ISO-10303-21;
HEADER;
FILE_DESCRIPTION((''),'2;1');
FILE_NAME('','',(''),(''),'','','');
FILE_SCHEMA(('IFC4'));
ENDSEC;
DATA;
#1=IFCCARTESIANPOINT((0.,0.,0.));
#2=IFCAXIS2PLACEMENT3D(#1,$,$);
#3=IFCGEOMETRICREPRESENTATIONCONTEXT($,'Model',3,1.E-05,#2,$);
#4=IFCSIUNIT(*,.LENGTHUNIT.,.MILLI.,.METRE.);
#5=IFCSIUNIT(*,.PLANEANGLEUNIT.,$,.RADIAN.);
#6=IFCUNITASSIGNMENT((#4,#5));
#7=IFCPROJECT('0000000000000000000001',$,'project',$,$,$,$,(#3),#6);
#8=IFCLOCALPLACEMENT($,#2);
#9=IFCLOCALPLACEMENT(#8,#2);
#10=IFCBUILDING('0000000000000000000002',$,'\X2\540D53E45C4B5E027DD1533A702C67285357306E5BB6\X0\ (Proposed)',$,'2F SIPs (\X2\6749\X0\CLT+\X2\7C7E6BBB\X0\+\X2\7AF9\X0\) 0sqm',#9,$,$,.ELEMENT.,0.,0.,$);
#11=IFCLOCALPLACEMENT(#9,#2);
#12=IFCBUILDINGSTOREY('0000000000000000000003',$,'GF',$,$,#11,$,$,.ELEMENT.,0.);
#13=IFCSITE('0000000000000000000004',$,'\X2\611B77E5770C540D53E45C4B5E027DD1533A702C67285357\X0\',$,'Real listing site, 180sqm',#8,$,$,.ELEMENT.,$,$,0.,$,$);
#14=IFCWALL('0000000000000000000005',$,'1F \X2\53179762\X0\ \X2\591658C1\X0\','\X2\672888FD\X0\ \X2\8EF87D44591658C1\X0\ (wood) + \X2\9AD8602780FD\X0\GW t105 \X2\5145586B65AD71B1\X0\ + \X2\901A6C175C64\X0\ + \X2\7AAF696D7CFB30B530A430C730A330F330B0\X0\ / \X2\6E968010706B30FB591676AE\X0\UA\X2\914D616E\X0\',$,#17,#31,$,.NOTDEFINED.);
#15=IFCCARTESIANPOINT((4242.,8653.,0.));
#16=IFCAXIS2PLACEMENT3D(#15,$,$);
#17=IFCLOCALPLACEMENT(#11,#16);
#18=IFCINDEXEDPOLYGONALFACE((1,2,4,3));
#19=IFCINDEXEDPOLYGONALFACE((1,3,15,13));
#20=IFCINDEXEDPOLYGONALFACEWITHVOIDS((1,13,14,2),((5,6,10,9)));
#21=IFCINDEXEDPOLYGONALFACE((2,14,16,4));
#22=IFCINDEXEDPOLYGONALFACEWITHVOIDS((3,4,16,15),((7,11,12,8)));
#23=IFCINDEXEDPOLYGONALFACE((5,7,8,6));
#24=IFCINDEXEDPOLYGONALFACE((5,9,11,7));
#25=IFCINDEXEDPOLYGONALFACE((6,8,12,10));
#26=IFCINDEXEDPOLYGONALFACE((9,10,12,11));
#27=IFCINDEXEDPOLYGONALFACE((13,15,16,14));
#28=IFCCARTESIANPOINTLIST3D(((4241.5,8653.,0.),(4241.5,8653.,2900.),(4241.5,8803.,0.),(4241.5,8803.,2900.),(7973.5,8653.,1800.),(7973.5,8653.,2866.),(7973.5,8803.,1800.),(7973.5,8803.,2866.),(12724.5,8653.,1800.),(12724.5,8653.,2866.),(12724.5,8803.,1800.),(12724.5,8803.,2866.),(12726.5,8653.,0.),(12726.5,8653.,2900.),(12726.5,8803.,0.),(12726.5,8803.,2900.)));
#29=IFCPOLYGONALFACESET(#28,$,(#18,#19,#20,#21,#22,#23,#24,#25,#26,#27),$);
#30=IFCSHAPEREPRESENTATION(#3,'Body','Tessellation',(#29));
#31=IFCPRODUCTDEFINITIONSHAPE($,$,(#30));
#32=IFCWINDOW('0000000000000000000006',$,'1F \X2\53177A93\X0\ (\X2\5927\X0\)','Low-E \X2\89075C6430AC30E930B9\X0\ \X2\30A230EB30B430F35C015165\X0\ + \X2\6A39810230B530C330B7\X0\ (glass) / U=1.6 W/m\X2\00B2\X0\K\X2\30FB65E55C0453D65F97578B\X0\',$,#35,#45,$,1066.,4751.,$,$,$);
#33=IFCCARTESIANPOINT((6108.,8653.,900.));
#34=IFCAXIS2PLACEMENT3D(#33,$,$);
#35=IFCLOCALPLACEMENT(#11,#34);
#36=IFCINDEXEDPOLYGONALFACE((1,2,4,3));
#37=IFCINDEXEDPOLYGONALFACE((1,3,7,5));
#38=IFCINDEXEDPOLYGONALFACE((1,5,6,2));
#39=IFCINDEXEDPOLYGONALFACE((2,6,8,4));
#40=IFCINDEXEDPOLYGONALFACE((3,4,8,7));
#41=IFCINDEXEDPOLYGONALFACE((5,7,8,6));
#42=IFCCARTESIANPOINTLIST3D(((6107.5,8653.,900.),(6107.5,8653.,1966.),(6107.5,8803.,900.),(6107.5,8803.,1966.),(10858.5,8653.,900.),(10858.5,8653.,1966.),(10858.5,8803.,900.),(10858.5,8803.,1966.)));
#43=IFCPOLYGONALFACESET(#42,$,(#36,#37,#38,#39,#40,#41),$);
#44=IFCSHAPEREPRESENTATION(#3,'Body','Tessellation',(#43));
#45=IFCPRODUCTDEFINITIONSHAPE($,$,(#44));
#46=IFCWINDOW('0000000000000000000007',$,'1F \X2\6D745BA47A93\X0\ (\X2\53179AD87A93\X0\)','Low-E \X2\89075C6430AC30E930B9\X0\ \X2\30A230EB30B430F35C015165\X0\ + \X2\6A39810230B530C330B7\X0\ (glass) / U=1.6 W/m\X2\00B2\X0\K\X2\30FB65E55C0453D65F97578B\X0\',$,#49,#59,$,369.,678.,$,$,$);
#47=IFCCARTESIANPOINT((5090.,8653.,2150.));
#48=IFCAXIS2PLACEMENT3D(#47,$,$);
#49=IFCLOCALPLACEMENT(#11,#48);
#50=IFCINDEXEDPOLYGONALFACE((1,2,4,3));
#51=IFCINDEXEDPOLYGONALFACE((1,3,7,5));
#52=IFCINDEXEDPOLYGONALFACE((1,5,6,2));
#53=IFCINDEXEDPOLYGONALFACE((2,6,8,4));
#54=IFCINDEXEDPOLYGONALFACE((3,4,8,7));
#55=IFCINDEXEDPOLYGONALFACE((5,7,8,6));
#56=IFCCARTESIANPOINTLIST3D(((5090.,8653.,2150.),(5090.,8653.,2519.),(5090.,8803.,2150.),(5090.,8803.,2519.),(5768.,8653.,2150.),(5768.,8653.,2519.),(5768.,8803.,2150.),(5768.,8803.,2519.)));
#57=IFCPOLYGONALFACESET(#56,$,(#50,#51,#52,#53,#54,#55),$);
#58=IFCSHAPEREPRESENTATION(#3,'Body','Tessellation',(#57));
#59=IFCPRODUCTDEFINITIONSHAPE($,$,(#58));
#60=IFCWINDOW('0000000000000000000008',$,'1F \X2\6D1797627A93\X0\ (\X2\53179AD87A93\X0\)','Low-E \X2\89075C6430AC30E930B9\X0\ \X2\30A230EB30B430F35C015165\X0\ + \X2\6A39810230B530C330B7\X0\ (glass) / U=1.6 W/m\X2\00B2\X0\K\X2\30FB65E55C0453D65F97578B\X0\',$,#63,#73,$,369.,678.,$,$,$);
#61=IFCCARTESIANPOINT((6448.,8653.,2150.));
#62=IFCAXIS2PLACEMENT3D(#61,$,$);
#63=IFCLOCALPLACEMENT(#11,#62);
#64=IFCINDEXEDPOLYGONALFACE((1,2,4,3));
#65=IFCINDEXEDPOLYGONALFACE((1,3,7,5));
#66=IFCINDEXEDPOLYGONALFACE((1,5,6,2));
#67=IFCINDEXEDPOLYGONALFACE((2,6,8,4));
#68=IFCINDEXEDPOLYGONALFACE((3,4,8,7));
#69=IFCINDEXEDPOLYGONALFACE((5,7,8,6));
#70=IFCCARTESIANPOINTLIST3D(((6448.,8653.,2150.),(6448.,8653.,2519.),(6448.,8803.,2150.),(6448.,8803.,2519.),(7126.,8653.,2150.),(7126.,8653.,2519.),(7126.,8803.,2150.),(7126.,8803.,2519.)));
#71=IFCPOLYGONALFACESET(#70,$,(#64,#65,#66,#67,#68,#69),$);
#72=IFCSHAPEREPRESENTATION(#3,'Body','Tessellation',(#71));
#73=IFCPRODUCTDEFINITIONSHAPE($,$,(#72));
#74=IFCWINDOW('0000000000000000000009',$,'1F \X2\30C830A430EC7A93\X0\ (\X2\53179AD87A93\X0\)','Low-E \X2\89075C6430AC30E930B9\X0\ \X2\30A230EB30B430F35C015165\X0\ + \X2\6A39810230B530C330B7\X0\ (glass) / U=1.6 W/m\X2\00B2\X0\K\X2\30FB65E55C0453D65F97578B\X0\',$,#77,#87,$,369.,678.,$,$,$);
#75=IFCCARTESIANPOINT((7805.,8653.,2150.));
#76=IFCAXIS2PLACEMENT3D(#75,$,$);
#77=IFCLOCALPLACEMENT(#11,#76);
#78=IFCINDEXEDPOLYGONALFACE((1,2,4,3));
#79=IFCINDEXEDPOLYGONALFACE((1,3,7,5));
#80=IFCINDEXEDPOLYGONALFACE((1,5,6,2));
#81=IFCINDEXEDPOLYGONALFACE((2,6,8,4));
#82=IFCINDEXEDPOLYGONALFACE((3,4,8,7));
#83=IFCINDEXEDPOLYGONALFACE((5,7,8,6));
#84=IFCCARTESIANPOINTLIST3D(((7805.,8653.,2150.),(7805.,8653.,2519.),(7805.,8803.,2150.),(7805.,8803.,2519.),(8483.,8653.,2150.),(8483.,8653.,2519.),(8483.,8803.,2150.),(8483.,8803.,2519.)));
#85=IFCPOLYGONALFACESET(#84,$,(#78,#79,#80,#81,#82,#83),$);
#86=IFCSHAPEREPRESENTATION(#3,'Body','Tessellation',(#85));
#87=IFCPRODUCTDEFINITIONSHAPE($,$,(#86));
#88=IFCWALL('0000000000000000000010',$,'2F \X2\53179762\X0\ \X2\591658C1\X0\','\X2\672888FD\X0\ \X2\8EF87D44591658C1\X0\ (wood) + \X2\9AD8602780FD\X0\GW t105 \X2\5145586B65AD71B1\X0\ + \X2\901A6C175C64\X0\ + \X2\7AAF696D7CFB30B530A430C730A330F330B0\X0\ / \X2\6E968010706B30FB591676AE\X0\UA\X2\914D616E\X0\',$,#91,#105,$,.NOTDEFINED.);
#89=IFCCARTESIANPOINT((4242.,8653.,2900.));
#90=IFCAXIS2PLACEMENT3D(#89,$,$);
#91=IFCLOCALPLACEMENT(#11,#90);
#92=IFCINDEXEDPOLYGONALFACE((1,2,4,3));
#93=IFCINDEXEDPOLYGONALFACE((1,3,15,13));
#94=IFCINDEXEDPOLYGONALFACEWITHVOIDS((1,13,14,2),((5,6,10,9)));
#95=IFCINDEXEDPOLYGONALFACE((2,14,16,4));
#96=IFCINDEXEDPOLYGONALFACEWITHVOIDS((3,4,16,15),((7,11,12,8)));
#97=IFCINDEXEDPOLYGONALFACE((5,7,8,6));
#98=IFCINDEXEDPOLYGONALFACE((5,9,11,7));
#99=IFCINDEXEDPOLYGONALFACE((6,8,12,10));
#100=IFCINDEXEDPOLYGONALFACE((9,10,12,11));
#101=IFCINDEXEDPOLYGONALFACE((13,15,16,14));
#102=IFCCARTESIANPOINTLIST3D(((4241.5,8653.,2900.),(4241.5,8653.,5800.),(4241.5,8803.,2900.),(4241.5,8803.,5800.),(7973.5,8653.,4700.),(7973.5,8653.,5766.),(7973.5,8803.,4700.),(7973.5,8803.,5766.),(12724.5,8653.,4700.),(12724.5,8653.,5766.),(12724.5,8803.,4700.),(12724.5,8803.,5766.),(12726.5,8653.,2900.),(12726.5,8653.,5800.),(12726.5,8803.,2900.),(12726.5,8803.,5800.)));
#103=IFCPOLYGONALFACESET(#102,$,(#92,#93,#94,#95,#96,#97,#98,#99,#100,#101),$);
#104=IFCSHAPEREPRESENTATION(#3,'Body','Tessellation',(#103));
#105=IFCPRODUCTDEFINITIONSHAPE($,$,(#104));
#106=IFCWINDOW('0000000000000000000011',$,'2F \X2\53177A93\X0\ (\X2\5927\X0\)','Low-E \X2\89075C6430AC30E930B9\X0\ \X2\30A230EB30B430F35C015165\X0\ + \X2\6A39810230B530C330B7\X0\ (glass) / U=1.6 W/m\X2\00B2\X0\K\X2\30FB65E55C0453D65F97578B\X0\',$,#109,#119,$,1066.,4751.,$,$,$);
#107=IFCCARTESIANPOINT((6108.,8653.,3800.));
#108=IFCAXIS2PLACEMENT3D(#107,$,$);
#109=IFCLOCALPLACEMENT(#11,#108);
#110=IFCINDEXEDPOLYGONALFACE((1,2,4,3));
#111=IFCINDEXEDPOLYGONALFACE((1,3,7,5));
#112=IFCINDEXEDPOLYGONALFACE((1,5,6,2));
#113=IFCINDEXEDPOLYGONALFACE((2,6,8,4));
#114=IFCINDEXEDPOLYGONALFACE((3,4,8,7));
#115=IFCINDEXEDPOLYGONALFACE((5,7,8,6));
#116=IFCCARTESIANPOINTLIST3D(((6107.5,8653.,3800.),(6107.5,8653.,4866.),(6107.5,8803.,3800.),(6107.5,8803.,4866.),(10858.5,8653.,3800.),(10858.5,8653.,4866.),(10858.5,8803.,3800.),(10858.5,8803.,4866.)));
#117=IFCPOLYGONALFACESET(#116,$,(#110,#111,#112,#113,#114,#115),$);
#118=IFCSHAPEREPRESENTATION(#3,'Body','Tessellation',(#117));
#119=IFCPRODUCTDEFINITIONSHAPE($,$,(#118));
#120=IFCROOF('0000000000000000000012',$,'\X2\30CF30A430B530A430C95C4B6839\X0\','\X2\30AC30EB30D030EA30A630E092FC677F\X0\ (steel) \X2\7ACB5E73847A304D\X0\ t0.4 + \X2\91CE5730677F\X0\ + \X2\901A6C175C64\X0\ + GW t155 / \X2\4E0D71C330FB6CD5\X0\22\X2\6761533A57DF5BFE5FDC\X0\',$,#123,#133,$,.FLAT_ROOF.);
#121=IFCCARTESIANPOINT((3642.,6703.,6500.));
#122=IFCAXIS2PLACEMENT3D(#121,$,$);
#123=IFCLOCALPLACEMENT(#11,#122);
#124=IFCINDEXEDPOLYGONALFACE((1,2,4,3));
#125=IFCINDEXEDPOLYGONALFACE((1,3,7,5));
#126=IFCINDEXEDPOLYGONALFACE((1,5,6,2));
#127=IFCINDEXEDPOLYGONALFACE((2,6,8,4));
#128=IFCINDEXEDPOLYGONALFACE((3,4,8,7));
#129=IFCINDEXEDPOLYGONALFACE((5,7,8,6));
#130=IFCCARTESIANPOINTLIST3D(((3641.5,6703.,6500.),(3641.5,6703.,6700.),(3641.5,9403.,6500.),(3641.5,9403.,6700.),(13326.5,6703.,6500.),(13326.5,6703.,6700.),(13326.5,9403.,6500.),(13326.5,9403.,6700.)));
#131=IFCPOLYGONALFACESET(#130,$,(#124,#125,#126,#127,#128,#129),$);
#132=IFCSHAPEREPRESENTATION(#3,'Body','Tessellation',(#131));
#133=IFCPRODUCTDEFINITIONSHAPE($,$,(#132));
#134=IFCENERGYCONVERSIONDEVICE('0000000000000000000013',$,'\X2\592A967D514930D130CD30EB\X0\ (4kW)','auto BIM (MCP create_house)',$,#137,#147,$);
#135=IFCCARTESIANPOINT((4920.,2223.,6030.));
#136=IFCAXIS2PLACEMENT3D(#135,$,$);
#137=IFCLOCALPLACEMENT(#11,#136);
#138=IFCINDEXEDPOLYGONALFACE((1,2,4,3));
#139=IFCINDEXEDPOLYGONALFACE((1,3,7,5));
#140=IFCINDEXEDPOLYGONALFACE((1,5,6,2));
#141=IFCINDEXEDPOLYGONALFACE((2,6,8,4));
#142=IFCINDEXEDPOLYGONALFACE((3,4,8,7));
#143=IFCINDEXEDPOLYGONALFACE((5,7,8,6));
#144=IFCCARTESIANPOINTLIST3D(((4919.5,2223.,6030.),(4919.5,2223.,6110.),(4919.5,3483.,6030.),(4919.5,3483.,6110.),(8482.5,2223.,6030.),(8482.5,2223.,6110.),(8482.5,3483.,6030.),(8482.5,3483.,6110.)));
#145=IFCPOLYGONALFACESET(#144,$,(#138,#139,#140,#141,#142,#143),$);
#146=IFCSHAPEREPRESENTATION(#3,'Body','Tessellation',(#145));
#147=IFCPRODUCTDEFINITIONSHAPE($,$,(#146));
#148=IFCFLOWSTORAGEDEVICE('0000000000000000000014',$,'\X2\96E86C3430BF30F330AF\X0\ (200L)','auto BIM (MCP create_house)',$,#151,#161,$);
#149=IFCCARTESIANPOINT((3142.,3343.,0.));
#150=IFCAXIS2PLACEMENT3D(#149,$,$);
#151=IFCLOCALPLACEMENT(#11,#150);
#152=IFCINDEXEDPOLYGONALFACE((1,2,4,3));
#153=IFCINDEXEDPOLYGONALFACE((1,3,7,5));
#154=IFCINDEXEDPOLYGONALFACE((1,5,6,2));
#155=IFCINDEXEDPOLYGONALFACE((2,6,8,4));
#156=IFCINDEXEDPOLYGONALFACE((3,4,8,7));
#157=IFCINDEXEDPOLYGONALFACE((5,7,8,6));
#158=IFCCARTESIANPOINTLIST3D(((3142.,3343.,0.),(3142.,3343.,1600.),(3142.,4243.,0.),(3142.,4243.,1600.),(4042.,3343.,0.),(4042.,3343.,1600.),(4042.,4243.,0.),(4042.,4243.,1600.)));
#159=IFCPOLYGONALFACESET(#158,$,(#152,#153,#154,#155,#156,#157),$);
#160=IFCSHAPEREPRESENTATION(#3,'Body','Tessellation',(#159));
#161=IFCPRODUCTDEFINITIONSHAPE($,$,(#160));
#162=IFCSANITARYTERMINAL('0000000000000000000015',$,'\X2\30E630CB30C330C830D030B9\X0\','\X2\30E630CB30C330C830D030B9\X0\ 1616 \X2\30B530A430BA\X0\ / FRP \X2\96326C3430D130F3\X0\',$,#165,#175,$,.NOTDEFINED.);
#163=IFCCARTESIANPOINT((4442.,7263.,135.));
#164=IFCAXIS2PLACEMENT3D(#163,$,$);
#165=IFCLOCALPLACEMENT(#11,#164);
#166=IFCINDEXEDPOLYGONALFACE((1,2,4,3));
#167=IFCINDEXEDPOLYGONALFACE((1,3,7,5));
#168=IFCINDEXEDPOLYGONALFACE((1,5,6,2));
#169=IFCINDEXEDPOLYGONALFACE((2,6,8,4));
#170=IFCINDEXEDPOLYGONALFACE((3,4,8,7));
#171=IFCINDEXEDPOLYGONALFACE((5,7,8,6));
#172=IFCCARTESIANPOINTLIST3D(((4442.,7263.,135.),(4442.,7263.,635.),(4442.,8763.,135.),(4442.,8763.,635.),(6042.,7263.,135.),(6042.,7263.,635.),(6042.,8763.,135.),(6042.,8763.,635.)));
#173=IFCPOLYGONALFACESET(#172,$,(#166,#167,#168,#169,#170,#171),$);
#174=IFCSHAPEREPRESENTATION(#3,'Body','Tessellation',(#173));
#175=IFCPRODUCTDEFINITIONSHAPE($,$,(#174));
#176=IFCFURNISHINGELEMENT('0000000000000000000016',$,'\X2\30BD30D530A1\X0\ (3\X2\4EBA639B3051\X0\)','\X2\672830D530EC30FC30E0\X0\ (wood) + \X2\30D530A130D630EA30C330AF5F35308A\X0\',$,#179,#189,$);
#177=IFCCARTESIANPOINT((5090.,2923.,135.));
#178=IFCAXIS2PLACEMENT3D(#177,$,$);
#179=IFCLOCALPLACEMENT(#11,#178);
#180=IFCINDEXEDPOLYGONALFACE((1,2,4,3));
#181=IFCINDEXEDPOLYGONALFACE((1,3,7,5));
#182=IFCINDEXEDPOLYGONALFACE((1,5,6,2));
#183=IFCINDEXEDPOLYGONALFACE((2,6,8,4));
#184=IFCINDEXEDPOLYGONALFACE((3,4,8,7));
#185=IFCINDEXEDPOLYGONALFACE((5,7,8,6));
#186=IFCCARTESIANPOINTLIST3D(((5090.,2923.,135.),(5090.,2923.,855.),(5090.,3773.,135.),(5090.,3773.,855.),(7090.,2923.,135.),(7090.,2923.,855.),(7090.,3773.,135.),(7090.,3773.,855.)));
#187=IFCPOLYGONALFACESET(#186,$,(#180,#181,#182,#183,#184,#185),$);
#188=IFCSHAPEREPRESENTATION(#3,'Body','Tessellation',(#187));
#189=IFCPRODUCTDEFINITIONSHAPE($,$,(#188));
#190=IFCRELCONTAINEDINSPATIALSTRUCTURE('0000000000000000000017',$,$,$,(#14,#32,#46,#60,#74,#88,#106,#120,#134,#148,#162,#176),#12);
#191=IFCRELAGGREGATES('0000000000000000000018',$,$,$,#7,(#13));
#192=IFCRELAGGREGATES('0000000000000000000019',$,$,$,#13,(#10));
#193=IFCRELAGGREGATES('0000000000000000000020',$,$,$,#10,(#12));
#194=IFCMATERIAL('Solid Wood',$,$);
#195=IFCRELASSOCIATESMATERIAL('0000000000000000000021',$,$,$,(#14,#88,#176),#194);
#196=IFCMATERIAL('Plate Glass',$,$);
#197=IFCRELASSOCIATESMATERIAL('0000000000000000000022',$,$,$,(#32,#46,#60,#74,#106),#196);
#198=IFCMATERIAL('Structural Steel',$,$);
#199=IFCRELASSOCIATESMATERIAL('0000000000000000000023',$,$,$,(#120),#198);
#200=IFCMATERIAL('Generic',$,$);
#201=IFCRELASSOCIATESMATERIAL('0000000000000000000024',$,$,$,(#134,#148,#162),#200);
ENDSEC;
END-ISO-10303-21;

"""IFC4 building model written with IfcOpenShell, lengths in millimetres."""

from ifc_helpers import new_model, si_unit, frame, frame_2d, origin, place, context, project, spatial, rectangle, extrude, material, element, fill, save


model = new_model("IFC4")

# Units and contexts
model_context = context("Model", 3, precision=1e-05, world=origin())
ifc_project = project(units=[si_unit("LENGTHUNIT", "METRE", prefix="MILLI"), si_unit("PLANEANGLEUNIT", "RADIAN")], contexts=[model_context])

# Site, building, storey
site_placement = place(None, origin())
site = spatial("IfcSite", under=ifc_project, at=site_placement, Name="愛知県名古屋市緑区瀬木南", ObjectType="Real listing site, 180sqm", CompositionType="ELEMENT", RefElevation=0.0)
building_placement = place(site_placement, origin())
building = spatial("IfcBuilding", under=site, at=building_placement, Name="名古屋市緑区瀬木南の家 (Proposed)", ObjectType="2F SIPs (杉CLT+籾殻+竹) 0sqm", CompositionType="ELEMENT", ElevationOfRefHeight=0.0, ElevationOfTerrain=0.0)
storey_placement = place(building_placement, origin())
storey = spatial("IfcBuildingStorey", under=building, at=storey_placement, Name="GF", CompositionType="ELEMENT", Elevation=0.0)

# Wall, openings, windows
ifc_material_1 = material(Name="Solid Wood")
wall_1_placement = place(storey_placement, frame((4242.0, 8653.0, 0.0)))
wall_1 = element("IfcWall", 1, at=wall_1_placement, inside=storey, material=ifc_material_1, Name="1F 北面 外壁", Description="木製 軸組外壁 (wood) + 高性能GW t105 充填断熱 + 通気層 + 窯業系サイディング / 準耐火・外皮UA配慮", PredefinedType="NOTDEFINED", context=model_context, shape_type="SweptSolid", body=[
    extrude(rectangle(XDim=8485.0, YDim=150.0, at=frame_2d((4242.0, 75.0))), frame((4242.0, 8653.0, 0.0)), (0.0, 0.0, 1.0), 2900.0),
])
opening_1_placement = place(storey_placement, frame((6108.0, 8653.0, 900.0)))
opening_1 = element("IfcOpeningElement", 2, at=opening_1_placement, cuts=wall_1, PredefinedType="NOTDEFINED", context=model_context, shape_type="SweptSolid", body=[
    extrude(rectangle(XDim=4751.0, YDim=150.0, at=frame_2d((2375.0, 75.0))), frame((6108.0, 8653.0, 900.0)), (0.0, 0.0, 1.0), 1066.0),
])
opening_2_placement = place(storey_placement, frame((5090.0, 8653.0, 2150.0)))
opening_2 = element("IfcOpeningElement", 3, at=opening_2_placement, cuts=wall_1, PredefinedType="NOTDEFINED", context=model_context, shape_type="SweptSolid", body=[
    extrude(rectangle(XDim=678.0, YDim=150.0, at=frame_2d((339.0, 75.0))), frame((5090.0, 8653.0, 2150.0)), (0.0, 0.0, 1.0), 369.0),
])
opening_3_placement = place(storey_placement, frame((6448.0, 8653.0, 2150.0)))
opening_3 = element("IfcOpeningElement", 4, at=opening_3_placement, cuts=wall_1, PredefinedType="NOTDEFINED", context=model_context, shape_type="SweptSolid", body=[
    extrude(rectangle(XDim=678.0, YDim=150.0, at=frame_2d((339.0, 75.0))), frame((6448.0, 8653.0, 2150.0)), (0.0, 0.0, 1.0), 369.0),
])
opening_4_placement = place(storey_placement, frame((7805.0, 8653.0, 2150.0)))
opening_4 = element("IfcOpeningElement", 5, at=opening_4_placement, cuts=wall_1, PredefinedType="NOTDEFINED", context=model_context, shape_type="SweptSolid", body=[
    extrude(rectangle(XDim=678.0, YDim=150.0, at=frame_2d((339.0, 75.0))), frame((7805.0, 8653.0, 2150.0)), (0.0, 0.0, 1.0), 369.0),
])
ifc_material_2 = material(Name="Plate Glass")
window_1_placement = place(storey_placement, frame((6108.0, 8653.0, 900.0)))
window_1 = element("IfcWindow", 6, at=window_1_placement, inside=storey, material=ifc_material_2, Name="1F 北窓 (大)", Description="Low-E 複層ガラス アルゴン封入 + 樹脂サッシ (glass) / U=1.6 W/m²K・日射取得型", OverallHeight=1066.0, OverallWidth=4751.0, context=model_context, shape_type="SweptSolid", body=[
    extrude(rectangle(XDim=4751.0, YDim=150.0, at=frame_2d((2375.0, 75.0))), frame((6108.0, 8653.0, 900.0)), (0.0, 0.0, 1.0), 1066.0),
])
fill(opening_1, window_1)
window_2_placement = place(storey_placement, frame((5090.0, 8653.0, 2150.0)))
window_2 = element("IfcWindow", 7, at=window_2_placement, inside=storey, material=ifc_material_2, Name="1F 浴室窓 (北高窓)", Description="Low-E 複層ガラス アルゴン封入 + 樹脂サッシ (glass) / U=1.6 W/m²K・日射取得型", OverallHeight=369.0, OverallWidth=678.0, context=model_context, shape_type="SweptSolid", body=[
    extrude(rectangle(XDim=678.0, YDim=150.0, at=frame_2d((339.0, 75.0))), frame((5090.0, 8653.0, 2150.0)), (0.0, 0.0, 1.0), 369.0),
])
fill(opening_2, window_2)
window_3_placement = place(storey_placement, frame((6448.0, 8653.0, 2150.0)))
window_3 = element("IfcWindow", 8, at=window_3_placement, inside=storey, material=ifc_material_2, Name="1F 洗面窓 (北高窓)", Description="Low-E 複層ガラス アルゴン封入 + 樹脂サッシ (glass) / U=1.6 W/m²K・日射取得型", OverallHeight=369.0, OverallWidth=678.0, context=model_context, shape_type="SweptSolid", body=[
    extrude(rectangle(XDim=678.0, YDim=150.0, at=frame_2d((339.0, 75.0))), frame((6448.0, 8653.0, 2150.0)), (0.0, 0.0, 1.0), 369.0),
])
fill(opening_3, window_3)
window_4_placement = place(storey_placement, frame((7805.0, 8653.0, 2150.0)))
window_4 = element("IfcWindow", 9, at=window_4_placement, inside=storey, material=ifc_material_2, Name="1F トイレ窓 (北高窓)", Description="Low-E 複層ガラス アルゴン封入 + 樹脂サッシ (glass) / U=1.6 W/m²K・日射取得型", OverallHeight=369.0, OverallWidth=678.0, context=model_context, shape_type="SweptSolid", body=[
    extrude(rectangle(XDim=678.0, YDim=150.0, at=frame_2d((339.0, 75.0))), frame((7805.0, 8653.0, 2150.0)), (0.0, 0.0, 1.0), 369.0),
])
fill(opening_4, window_4)

# Wall, opening, window
wall_2_placement = place(storey_placement, frame((4242.0, 8653.0, 2900.0)))
wall_2 = element("IfcWall", 10, at=wall_2_placement, inside=storey, material=ifc_material_1, Name="2F 北面 外壁", Description="木製 軸組外壁 (wood) + 高性能GW t105 充填断熱 + 通気層 + 窯業系サイディング / 準耐火・外皮UA配慮", PredefinedType="NOTDEFINED", context=model_context, shape_type="SweptSolid", body=[
    extrude(rectangle(XDim=8485.0, YDim=150.0, at=frame_2d((4242.0, 75.0))), frame((4242.0, 8653.0, 2900.0)), (0.0, 0.0, 1.0), 2900.0),
])
opening_5_placement = place(storey_placement, frame((6108.0, 8653.0, 3800.0)))
opening_5 = element("IfcOpeningElement", 11, at=opening_5_placement, cuts=wall_2, PredefinedType="NOTDEFINED", context=model_context, shape_type="SweptSolid", body=[
    extrude(rectangle(XDim=4751.0, YDim=150.0, at=frame_2d((2375.0, 75.0))), frame((6108.0, 8653.0, 3800.0)), (0.0, 0.0, 1.0), 1066.0),
])
window_5_placement = place(storey_placement, frame((6108.0, 8653.0, 3800.0)))
window_5 = element("IfcWindow", 12, at=window_5_placement, inside=storey, material=ifc_material_2, Name="2F 北窓 (大)", Description="Low-E 複層ガラス アルゴン封入 + 樹脂サッシ (glass) / U=1.6 W/m²K・日射取得型", OverallHeight=1066.0, OverallWidth=4751.0, context=model_context, shape_type="SweptSolid", body=[
    extrude(rectangle(XDim=4751.0, YDim=150.0, at=frame_2d((2375.0, 75.0))), frame((6108.0, 8653.0, 3800.0)), (0.0, 0.0, 1.0), 1066.0),
])
fill(opening_5, window_5)

# Roof
ifc_material_3 = material(Name="Structural Steel")
roof_placement = place(storey_placement, frame((3642.0, 6703.0, 6500.0)))
element("IfcRoof", 13, at=roof_placement, inside=storey, material=ifc_material_3, Name="ハイサイド屋根", Description="ガルバリウム鋼板 (steel) 立平葺き t0.4 + 野地板 + 通気層 + GW t155 / 不燃・法22条区域対応", PredefinedType="FLAT_ROOF", context=model_context, shape_type="SweptSolid", body=[
    extrude(rectangle(XDim=9685.0, YDim=2700.0, at=frame_2d((4842.0, 1350.0))), frame((3642.0, 6703.0, 6500.0)), (0.0, 0.0, 1.0), 200.0),
])

# Energy conversion device
ifc_material_4 = material(Name="Generic")
energy_conversion_device_placement = place(storey_placement, frame((4920.0, 2223.0, 6030.0)))
element("IfcEnergyConversionDevice", 14, at=energy_conversion_device_placement, inside=storey, material=ifc_material_4, Name="太陽光パネル (4kW)", Description="auto BIM (MCP create_house)", context=model_context, shape_type="SweptSolid", body=[
    extrude(rectangle(XDim=3563.0, YDim=1260.0, at=frame_2d((1781.0, 630.0))), frame((4920.0, 2223.0, 6030.0)), (0.0, 0.0, 1.0), 80.0),
])

# Flow storage device
flow_storage_device_placement = place(storey_placement, frame((3142.0, 3343.0, 0.0)))
element("IfcFlowStorageDevice", 15, at=flow_storage_device_placement, inside=storey, material=ifc_material_4, Name="雨水タンク (200L)", Description="auto BIM (MCP create_house)", context=model_context, shape_type="SweptSolid", body=[
    extrude(rectangle(XDim=900.0, YDim=900.0, at=frame_2d((450.0, 450.0))), frame((3142.0, 3343.0, 0.0)), (0.0, 0.0, 1.0), 1600.0),
])

# Sanitary terminal
sanitary_terminal_placement = place(storey_placement, frame((4442.0, 7263.0, 135.0)))
element("IfcSanitaryTerminal", 16, at=sanitary_terminal_placement, inside=storey, material=ifc_material_4, Name="ユニットバス", Description="ユニットバス 1616 サイズ / FRP 防水パン", PredefinedType="NOTDEFINED", context=model_context, shape_type="SweptSolid", body=[
    extrude(rectangle(XDim=1600.0, YDim=1500.0, at=frame_2d((800.0, 750.0))), frame((4442.0, 7263.0, 135.0)), (0.0, 0.0, 1.0), 500.0),
])

# Furnishing element
furnishing_1_placement = place(storey_placement, frame((5090.0, 2923.0, 135.0)))
element("IfcFurnishingElement", 17, at=furnishing_1_placement, inside=storey, material=ifc_material_1, Name="ソファ (3人掛け)", Description="木フレーム (wood) + ファブリック張り", context=model_context, shape_type="SweptSolid", body=[
    extrude(rectangle(XDim=2000.0, YDim=850.0, at=frame_2d((1000.0, 425.0))), frame((5090.0, 2923.0, 135.0)), (0.0, 0.0, 1.0), 720.0),
])

save(model, "model.ifc")
